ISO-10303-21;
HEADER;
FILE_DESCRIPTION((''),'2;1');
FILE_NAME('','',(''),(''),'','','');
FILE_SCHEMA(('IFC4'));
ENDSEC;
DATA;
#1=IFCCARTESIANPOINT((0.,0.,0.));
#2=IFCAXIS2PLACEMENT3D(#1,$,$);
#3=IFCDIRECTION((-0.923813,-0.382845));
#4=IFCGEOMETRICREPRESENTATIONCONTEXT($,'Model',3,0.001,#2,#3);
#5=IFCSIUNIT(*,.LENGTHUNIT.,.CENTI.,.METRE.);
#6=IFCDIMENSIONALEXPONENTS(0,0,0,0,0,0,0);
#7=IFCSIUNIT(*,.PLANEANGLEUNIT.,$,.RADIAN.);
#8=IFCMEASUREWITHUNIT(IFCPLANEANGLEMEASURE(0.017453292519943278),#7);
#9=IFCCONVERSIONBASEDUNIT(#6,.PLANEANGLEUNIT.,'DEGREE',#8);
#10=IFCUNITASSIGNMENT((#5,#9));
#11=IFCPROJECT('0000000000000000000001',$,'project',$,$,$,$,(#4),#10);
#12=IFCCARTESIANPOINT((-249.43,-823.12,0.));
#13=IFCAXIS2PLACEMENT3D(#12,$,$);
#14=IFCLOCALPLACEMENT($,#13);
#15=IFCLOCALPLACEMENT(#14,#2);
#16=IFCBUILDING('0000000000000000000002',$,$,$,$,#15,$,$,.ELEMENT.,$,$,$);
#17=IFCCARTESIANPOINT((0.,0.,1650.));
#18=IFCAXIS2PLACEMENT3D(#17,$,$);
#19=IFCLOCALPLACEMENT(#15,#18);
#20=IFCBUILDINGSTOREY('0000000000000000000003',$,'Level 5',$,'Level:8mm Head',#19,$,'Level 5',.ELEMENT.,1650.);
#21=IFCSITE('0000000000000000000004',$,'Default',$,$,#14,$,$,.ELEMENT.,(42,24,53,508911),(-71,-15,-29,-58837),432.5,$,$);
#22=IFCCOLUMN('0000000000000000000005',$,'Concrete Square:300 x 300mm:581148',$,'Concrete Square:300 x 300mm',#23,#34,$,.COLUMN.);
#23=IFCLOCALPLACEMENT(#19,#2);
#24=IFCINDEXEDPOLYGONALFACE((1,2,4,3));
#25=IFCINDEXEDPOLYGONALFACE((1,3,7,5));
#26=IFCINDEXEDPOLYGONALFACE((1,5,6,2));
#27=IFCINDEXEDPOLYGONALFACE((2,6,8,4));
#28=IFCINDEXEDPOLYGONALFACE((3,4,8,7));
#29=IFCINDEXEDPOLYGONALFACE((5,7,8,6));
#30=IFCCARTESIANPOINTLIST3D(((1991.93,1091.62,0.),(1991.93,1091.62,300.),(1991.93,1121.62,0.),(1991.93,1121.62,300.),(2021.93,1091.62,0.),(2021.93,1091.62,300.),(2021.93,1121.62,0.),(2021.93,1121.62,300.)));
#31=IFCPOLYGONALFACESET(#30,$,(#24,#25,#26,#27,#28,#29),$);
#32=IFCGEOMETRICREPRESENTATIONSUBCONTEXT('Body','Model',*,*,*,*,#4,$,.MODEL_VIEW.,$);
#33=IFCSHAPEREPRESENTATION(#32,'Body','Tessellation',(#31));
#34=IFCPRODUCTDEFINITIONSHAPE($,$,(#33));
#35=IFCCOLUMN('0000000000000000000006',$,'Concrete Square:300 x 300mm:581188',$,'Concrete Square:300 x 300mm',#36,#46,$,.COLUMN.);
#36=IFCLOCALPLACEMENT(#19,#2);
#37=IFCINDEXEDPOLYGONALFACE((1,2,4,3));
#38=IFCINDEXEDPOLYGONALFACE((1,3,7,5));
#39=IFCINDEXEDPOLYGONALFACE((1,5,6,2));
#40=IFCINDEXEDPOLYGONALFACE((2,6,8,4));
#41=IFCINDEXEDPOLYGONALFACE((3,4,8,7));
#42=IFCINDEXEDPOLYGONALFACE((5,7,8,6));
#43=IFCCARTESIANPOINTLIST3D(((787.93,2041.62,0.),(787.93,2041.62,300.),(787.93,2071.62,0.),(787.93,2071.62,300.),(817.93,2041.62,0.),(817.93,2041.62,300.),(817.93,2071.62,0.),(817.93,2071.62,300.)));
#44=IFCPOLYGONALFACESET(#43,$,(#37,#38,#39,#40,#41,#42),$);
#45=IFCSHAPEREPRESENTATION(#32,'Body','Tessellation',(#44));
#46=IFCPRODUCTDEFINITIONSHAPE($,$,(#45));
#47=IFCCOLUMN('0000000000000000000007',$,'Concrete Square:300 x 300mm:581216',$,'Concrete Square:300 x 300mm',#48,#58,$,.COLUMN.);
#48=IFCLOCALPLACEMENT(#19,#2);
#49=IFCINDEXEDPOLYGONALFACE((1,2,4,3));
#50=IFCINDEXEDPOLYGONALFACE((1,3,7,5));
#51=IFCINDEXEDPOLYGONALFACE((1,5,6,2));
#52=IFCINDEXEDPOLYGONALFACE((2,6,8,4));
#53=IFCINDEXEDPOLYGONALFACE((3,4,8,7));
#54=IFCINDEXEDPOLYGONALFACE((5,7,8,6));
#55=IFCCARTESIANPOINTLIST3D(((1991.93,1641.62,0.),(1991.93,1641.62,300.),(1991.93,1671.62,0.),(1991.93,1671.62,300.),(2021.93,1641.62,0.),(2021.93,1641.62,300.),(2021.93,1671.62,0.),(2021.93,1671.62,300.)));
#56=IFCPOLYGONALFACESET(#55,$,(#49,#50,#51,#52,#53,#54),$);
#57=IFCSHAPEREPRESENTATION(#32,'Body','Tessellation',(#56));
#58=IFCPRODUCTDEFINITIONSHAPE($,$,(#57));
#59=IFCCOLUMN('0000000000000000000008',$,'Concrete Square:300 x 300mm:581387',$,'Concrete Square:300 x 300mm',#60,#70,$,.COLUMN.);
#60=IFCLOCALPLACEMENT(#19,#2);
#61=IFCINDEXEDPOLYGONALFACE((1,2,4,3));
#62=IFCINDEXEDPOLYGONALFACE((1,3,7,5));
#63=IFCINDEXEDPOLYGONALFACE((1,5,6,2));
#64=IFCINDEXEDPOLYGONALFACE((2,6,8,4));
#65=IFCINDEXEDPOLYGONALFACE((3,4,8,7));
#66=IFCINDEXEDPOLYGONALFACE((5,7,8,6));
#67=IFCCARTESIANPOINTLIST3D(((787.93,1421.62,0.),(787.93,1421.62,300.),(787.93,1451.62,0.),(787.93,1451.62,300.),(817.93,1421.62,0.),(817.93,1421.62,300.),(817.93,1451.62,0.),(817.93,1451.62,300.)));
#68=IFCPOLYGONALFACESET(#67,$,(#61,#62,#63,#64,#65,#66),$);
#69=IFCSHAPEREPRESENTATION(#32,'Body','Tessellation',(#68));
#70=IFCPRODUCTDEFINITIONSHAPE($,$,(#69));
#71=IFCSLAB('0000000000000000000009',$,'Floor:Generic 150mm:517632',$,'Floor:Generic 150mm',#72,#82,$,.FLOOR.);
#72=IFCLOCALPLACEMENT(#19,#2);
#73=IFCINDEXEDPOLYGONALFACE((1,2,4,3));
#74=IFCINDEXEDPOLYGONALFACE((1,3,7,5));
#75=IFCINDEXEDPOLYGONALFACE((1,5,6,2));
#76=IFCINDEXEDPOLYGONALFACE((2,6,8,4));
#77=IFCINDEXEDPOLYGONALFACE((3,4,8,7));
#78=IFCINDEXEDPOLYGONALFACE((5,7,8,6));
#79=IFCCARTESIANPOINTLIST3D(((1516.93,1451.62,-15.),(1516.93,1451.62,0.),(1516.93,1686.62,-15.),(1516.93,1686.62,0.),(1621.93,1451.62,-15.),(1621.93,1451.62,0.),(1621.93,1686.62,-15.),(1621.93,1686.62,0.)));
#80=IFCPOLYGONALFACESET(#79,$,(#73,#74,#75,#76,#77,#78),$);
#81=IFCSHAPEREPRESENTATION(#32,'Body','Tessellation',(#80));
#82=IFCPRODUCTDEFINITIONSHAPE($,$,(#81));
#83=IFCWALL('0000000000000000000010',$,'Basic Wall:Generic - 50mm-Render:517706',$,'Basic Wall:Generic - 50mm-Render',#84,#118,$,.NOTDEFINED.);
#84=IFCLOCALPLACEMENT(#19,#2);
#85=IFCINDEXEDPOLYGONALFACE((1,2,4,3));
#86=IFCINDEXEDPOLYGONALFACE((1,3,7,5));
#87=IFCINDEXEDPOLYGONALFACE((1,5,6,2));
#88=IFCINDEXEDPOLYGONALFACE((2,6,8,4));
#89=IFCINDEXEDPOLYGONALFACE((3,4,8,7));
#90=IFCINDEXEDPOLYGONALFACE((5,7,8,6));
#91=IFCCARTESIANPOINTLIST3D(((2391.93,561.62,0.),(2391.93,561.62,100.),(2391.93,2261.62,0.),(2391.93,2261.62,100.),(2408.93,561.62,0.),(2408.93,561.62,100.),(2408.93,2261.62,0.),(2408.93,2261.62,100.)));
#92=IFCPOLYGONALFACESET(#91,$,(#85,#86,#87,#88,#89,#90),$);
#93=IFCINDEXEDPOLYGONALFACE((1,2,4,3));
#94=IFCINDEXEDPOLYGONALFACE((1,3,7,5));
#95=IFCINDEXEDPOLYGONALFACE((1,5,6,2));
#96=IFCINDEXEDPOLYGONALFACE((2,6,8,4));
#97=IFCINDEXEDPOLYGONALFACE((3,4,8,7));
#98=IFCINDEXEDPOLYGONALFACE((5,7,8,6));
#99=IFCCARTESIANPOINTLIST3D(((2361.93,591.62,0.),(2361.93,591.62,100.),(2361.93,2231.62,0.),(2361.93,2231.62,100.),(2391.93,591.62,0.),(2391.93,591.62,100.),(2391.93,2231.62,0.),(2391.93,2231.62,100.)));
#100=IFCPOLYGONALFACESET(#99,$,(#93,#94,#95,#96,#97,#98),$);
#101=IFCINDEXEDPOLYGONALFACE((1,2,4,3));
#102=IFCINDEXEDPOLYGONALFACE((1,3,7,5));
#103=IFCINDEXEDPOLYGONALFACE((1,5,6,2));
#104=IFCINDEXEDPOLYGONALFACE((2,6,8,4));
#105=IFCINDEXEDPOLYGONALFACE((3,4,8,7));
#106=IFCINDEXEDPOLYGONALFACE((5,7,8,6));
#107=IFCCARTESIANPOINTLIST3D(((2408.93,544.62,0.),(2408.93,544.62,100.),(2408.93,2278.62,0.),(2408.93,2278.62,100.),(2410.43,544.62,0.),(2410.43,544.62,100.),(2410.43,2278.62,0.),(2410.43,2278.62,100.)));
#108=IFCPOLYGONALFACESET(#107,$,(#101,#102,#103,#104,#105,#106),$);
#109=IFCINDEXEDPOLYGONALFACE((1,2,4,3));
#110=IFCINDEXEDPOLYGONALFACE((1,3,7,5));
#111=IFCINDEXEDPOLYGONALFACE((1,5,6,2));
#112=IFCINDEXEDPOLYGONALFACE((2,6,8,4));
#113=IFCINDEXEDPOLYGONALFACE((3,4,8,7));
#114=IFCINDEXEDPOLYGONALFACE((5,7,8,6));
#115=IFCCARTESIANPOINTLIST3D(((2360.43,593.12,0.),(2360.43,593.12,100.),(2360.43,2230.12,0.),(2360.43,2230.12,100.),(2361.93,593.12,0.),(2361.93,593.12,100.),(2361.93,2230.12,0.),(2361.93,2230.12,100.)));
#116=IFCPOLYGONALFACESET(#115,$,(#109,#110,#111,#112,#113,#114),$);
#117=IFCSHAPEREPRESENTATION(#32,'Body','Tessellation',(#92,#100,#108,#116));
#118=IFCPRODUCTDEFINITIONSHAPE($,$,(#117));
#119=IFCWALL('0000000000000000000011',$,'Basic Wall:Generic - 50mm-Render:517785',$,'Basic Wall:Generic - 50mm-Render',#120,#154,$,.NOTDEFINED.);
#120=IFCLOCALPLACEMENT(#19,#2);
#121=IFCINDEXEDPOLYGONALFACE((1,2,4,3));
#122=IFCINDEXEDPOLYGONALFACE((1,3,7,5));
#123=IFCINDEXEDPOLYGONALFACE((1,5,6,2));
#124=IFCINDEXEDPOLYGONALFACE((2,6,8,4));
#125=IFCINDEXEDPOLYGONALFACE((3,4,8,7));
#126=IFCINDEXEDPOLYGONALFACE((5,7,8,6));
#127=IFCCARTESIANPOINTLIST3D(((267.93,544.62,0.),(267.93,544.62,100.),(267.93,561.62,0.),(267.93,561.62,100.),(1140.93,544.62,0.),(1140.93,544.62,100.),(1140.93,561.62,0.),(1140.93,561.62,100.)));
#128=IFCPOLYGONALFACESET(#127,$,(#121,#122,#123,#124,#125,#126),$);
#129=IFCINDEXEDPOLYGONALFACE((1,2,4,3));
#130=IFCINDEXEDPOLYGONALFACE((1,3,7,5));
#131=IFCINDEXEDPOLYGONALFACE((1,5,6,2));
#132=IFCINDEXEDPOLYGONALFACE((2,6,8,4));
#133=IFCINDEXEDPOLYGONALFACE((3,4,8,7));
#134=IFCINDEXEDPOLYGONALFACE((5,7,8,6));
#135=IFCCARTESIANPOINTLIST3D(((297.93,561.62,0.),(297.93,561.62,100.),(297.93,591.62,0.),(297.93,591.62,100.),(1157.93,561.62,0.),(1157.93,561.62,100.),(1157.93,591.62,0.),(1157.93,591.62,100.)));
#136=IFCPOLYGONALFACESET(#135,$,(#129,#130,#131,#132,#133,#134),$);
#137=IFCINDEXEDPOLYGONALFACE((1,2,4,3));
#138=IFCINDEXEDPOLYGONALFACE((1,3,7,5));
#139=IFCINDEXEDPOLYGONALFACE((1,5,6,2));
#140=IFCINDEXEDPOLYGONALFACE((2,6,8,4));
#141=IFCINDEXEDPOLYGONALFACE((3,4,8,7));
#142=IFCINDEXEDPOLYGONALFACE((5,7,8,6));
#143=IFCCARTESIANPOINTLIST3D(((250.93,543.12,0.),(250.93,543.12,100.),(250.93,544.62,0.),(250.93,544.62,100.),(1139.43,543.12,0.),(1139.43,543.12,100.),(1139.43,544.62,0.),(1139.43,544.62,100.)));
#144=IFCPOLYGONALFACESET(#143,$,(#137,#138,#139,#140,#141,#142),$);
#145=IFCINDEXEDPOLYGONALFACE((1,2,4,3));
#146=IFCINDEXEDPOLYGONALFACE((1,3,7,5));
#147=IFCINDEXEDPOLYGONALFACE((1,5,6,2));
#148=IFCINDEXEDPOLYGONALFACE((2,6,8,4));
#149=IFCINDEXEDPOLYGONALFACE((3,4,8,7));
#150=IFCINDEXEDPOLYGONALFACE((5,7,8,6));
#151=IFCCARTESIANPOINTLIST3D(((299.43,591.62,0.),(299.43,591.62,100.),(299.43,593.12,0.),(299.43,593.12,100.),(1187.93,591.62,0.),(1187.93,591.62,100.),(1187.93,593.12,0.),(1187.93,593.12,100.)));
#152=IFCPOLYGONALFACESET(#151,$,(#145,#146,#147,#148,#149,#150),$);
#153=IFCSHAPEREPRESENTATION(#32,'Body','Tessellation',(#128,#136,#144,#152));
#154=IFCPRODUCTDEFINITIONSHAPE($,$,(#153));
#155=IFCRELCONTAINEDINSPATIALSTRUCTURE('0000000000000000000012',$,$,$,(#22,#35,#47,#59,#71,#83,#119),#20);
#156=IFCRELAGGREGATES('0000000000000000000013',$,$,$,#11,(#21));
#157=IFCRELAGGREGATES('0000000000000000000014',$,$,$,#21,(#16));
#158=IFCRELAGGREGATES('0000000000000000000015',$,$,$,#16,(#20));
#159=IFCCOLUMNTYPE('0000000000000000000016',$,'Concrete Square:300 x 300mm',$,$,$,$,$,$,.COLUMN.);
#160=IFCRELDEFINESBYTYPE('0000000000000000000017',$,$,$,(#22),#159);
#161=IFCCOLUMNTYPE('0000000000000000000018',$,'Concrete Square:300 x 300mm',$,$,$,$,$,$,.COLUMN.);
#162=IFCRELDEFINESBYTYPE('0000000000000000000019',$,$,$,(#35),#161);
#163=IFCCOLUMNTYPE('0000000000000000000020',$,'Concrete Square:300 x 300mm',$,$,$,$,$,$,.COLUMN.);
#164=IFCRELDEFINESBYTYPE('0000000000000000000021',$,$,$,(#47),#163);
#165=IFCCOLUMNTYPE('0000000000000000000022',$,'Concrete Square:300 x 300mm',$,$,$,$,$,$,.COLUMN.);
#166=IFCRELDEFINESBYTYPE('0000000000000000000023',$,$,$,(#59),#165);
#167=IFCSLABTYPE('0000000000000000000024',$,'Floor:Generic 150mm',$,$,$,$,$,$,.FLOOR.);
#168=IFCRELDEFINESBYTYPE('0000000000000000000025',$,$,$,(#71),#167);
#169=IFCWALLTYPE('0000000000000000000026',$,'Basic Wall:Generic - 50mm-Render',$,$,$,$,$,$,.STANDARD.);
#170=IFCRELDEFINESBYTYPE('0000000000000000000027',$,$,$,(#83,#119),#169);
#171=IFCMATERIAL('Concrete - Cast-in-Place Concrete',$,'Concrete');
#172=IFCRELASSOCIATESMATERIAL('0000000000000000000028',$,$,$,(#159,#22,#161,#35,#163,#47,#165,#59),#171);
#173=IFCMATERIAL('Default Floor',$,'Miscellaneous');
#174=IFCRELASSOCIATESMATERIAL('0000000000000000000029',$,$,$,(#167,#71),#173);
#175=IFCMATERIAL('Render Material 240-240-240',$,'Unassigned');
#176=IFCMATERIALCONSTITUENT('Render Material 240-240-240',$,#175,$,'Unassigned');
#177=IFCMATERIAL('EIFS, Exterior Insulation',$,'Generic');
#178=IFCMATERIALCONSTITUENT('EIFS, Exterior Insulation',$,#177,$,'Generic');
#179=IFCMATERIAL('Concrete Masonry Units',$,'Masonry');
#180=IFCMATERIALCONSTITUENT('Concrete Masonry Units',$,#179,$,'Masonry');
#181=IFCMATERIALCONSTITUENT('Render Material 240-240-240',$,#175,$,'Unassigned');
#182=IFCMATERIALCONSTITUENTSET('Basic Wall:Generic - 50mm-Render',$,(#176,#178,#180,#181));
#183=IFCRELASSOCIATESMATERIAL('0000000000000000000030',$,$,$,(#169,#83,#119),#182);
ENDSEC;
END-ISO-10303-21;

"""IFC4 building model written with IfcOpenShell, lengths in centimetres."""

from ifc_helpers import new_model, entity, si_unit, converted_unit, direction, frame, origin, place, context, subcontext, project, spatial, indexed_curve, outline, extrude, source, transform, mapped, material, constituent, constituent_set, type_object, type_shapes, element, save


model = new_model("IFC4")

# Units and contexts
model_context = context("Model", 3, precision=0.001, world=origin(), true_north=direction((-0.923813, -0.382845)))
body_context = subcontext(model_context, "Body", "Model", "MODEL_VIEW")
ifc_project = project(units=[si_unit("LENGTHUNIT", "METRE", prefix="CENTI"), converted_unit("PLANEANGLEUNIT", "DEGREE", entity("IfcPlaneAngleMeasure", 0.017453292519943278), si_unit("PLANEANGLEUNIT", "RADIAN"), dimensions=[0, 0, 0, 0, 0, 0, 0])], contexts=[model_context])

# Site, building, storey
site_placement = place(None, frame((-249.43, -823.12, 0.0)))
site = spatial("IfcSite", under=ifc_project, at=site_placement, Name="Default", CompositionType="ELEMENT", RefLatitude=(42, 24, 53, 508911), RefLongitude=(-71, -15, -29, -58837), RefElevation=432.5)
building_placement = place(site_placement, origin())
building = spatial("IfcBuilding", under=site, at=building_placement, CompositionType="ELEMENT")
storey_placement = place(building_placement, frame((0.0, 0.0, 1650.0)))
storey = spatial("IfcBuildingStorey", under=building, at=storey_placement, Name="Level 5", ObjectType="Level:8mm Head", LongName="Level 5", CompositionType="ELEMENT", Elevation=1650.0)

# Columns
ifc_material_1 = material(Name="Concrete - Cast-in-Place Concrete", Category="Concrete")
column_type_1 = type_object("IfcColumnType", Name="Concrete Square:300 x 300mm", PredefinedType="COLUMN", material=ifc_material_1)
shared_shape_1 = source(origin(), body_context, "Body", "SweptSolid", [
    extrude(outline(indexed_curve([(-15.0, -15.0), (15.0, -15.0), (15.0, 15.0), (-15.0, 15.0), (-15.0, -15.0)], self_intersect=False)), frame((2006.93, 1106.62, 1650.0), z_axis=(0.0, 0.0, 1.0), x_axis=(-1.0, 0.0, 0.0)), (0.0, 0.0, 1.0), 300.0),
])
type_shapes(column_type_1, [shared_shape_1])
column_1_placement = place(storey_placement, frame((0.0, 0.0, -1650.0)))
element("IfcColumn", 1, at=column_1_placement, inside=storey, type_object=column_type_1, material=ifc_material_1, Name="Concrete Square:300 x 300mm:581148", ObjectType="Concrete Square:300 x 300mm", PredefinedType="COLUMN", context=body_context, shape_type="MappedRepresentation", body=[
    mapped(shared_shape_1, transform((0.0, 0.0, 0.0), scale=1.0)),
])
column_type_2 = type_object("IfcColumnType", Name="Concrete Square:300 x 300mm", PredefinedType="COLUMN", material=ifc_material_1)
shared_shape_2 = source(origin(), body_context, "Body", "SweptSolid", [
    extrude(outline(indexed_curve([(-15.0, -15.0), (15.0, -15.0), (15.0, 15.0), (-15.0, 15.0), (-15.0, -15.0)], self_intersect=False)), frame((802.93, 2056.62, 1650.0), z_axis=(0.0, 0.0, 1.0), x_axis=(-1.0, 0.0, 0.0)), (0.0, 0.0, 1.0), 300.0),
])
type_shapes(column_type_2, [shared_shape_2])
column_2_placement = place(storey_placement, frame((0.0, 0.0, -1650.0)))
element("IfcColumn", 2, at=column_2_placement, inside=storey, type_object=column_type_2, material=ifc_material_1, Name="Concrete Square:300 x 300mm:581188", ObjectType="Concrete Square:300 x 300mm", PredefinedType="COLUMN", context=body_context, shape_type="MappedRepresentation", body=[
    mapped(shared_shape_2, transform((0.0, 0.0, 0.0), scale=1.0)),
])
column_type_3 = type_object("IfcColumnType", Name="Concrete Square:300 x 300mm", PredefinedType="COLUMN", material=ifc_material_1)
shared_shape_3 = source(origin(), body_context, "Body", "SweptSolid", [
    extrude(outline(indexed_curve([(-15.0, -15.0), (15.0, -15.0), (15.0, 15.0), (-15.0, 15.0), (-15.0, -15.0)], self_intersect=False)), frame((2006.93, 1656.62, 1650.0), z_axis=(0.0, 0.0, 1.0), x_axis=(-1.0, 0.0, 0.0)), (0.0, 0.0, 1.0), 300.0),
])
type_shapes(column_type_3, [shared_shape_3])
column_3_placement = place(storey_placement, frame((0.0, 0.0, -1650.0)))
element("IfcColumn", 3, at=column_3_placement, inside=storey, type_object=column_type_3, material=ifc_material_1, Name="Concrete Square:300 x 300mm:581216", ObjectType="Concrete Square:300 x 300mm", PredefinedType="COLUMN", context=body_context, shape_type="MappedRepresentation", body=[
    mapped(shared_shape_3, transform((0.0, 0.0, 0.0), scale=1.0)),
])
column_type_4 = type_object("IfcColumnType", Name="Concrete Square:300 x 300mm", PredefinedType="COLUMN", material=ifc_material_1)
shared_shape_4 = source(origin(), body_context, "Body", "SweptSolid", [
    extrude(outline(indexed_curve([(-15.0, -15.0), (15.0, -15.0), (15.0, 15.0), (-15.0, 15.0), (-15.0, -15.0)], self_intersect=False)), frame((802.93, 1436.62, 1650.0), z_axis=(0.0, 0.0, 1.0), x_axis=(-1.0, 0.0, 0.0)), (0.0, 0.0, 1.0), 300.0),
])
type_shapes(column_type_4, [shared_shape_4])
column_4_placement = place(storey_placement, frame((0.0, 0.0, -1650.0)))
element("IfcColumn", 4, at=column_4_placement, inside=storey, type_object=column_type_4, material=ifc_material_1, Name="Concrete Square:300 x 300mm:581387", ObjectType="Concrete Square:300 x 300mm", PredefinedType="COLUMN", context=body_context, shape_type="MappedRepresentation", body=[
    mapped(shared_shape_4, transform((0.0, 0.0, 0.0), scale=1.0)),
])

# Slab
ifc_material_2 = material(Name="Default Floor", Category="Miscellaneous")
slab_type_1 = type_object("IfcSlabType", Name="Floor:Generic 150mm", PredefinedType="FLOOR", material=ifc_material_2)
slab_1_placement = place(storey_placement, origin())
element("IfcSlab", 5, at=slab_1_placement, inside=storey, type_object=slab_type_1, material=ifc_material_2, Name="Floor:Generic 150mm:517632", ObjectType="Floor:Generic 150mm", PredefinedType="FLOOR", context=body_context, shape_type="SweptSolid", body=[
    extrude(outline(indexed_curve([(-117.5, -52.5), (117.5, -52.5), (117.5, 52.5), (-117.5, 52.5), (-117.5, -52.5)], self_intersect=False)), frame((1569.43, 1569.12, 0.0), z_axis=(0.0, 0.0, -1.0), x_axis=(0.0, 1.0, 0.0)), (0.0, 0.0, 1.0), 15.0),
])

# Walls
ifc_material_3 = material(Name="Render Material 240-240-240", Category="Unassigned")
ifc_constituent_1 = constituent(ifc_material_3, Name="Render Material 240-240-240", Category="Unassigned")
ifc_material_4 = material(Name="EIFS, Exterior Insulation", Category="Generic")
ifc_constituent_2 = constituent(ifc_material_4, Name="EIFS, Exterior Insulation", Category="Generic")
ifc_material_5 = material(Name="Concrete Masonry Units", Category="Masonry")
ifc_constituent_3 = constituent(ifc_material_5, Name="Concrete Masonry Units", Category="Masonry")
ifc_constituent_4 = constituent(ifc_material_3, Name="Render Material 240-240-240", Category="Unassigned")
ifc_constituent_set_1 = constituent_set(constituents=[ifc_constituent_1, ifc_constituent_2, ifc_constituent_3, ifc_constituent_4], Name="Basic Wall:Generic - 50mm-Render")
wall_type_1 = type_object("IfcWallType", Name="Basic Wall:Generic - 50mm-Render", PredefinedType="STANDARD", material=ifc_constituent_set_1)
wall_1_placement = place(storey_placement, frame((2385.43, 593.12, 0.0), z_axis=(0.0, 0.0, 1.0), x_axis=(0.0, 1.0, 0.0)))
element("IfcWall", 6, at=wall_1_placement, inside=storey, type_object=wall_type_1, material=ifc_constituent_set_1, Name="Basic Wall:Generic - 50mm-Render:517706", ObjectType="Basic Wall:Generic - 50mm-Render", PredefinedType="NOTDEFINED", context=body_context, shape_type="SweptSolid", body=[
    extrude(outline(indexed_curve([(-850.0, -8.5), (850.0, -8.5), (850.0, 8.5), (-850.0, 8.5), (-850.0, -8.5)], self_intersect=False)), frame((818.5, -15.0, 0.0)), (0.0, 0.0, 1.0), 100.0),
    extrude(outline(indexed_curve([(-820.0, -15.0), (820.0, -15.0), (820.0, 15.0), (-820.0, 15.0), (-820.0, -15.0)], self_intersect=False)), frame((818.5, 8.5, 0.0)), (0.0, 0.0, 1.0), 100.0),
    extrude(outline(indexed_curve([(-0.75, -867.0), (0.75, -867.0), (0.75, 867.0), (-0.75, 867.0), (-0.75, -867.0)], self_intersect=False)), frame((818.5, -24.25, 0.0), z_axis=(0.0, 0.0, 1.0), x_axis=(0.0, 1.0, 0.0)), (0.0, 0.0, 1.0), 100.0),
    extrude(outline(indexed_curve([(-0.75, -818.5), (0.75, -818.5), (0.75, 818.5), (-0.75, 818.5), (-0.75, -818.5)], self_intersect=False)), frame((818.5, 24.25, 0.0), z_axis=(0.0, 0.0, 1.0), x_axis=(0.0, -1.0, 0.0)), (0.0, 0.0, 1.0), 100.0),
])
wall_2_placement = place(storey_placement, frame((1139.43, 568.12, 0.0), z_axis=(0.0, 0.0, 1.0), x_axis=(-1.0, 0.0, 0.0)))
element("IfcWall", 7, at=wall_2_placement, inside=storey, type_object=wall_type_1, material=ifc_constituent_set_1, Name="Basic Wall:Generic - 50mm-Render:517785", ObjectType="Basic Wall:Generic - 50mm-Render", PredefinedType="NOTDEFINED", context=body_context, shape_type="SweptSolid", body=[
    extrude(outline(indexed_curve([(-436.5, -8.5), (436.5, -8.5), (436.5, 8.5), (-436.5, 8.5), (-436.5, -8.5)], self_intersect=False)), frame((435.0, 15.0, 0.0)), (0.0, 0.0, 1.0), 100.0),
    extrude(outline(indexed_curve([(-430.0, -15.0), (430.0, -15.0), (430.0, 15.0), (-430.0, 15.0), (-430.0, -15.0)], self_intersect=False)), frame((411.5, -8.5, 0.0)), (0.0, 0.0, 1.0), 100.0),
    extrude(outline(indexed_curve([(-0.75, -444.25), (0.75, -444.25), (0.75, 444.25), (-0.75, 444.25), (-0.75, -444.25)], self_intersect=False)), frame((444.25, 24.25, 0.0), z_axis=(0.0, 0.0, 1.0), x_axis=(0.0, -1.0, 0.0)), (0.0, 0.0, 1.0), 100.0),
    extrude(outline(indexed_curve([(-0.75, -444.25), (0.75, -444.25), (0.75, 444.25), (-0.75, 444.25), (-0.75, -444.25)], self_intersect=False)), frame((395.75, -24.25, 0.0), z_axis=(0.0, 0.0, 1.0), x_axis=(0.0, 1.0, 0.0)), (0.0, 0.0, 1.0), 100.0),
])

save(model, "model.ifc")
